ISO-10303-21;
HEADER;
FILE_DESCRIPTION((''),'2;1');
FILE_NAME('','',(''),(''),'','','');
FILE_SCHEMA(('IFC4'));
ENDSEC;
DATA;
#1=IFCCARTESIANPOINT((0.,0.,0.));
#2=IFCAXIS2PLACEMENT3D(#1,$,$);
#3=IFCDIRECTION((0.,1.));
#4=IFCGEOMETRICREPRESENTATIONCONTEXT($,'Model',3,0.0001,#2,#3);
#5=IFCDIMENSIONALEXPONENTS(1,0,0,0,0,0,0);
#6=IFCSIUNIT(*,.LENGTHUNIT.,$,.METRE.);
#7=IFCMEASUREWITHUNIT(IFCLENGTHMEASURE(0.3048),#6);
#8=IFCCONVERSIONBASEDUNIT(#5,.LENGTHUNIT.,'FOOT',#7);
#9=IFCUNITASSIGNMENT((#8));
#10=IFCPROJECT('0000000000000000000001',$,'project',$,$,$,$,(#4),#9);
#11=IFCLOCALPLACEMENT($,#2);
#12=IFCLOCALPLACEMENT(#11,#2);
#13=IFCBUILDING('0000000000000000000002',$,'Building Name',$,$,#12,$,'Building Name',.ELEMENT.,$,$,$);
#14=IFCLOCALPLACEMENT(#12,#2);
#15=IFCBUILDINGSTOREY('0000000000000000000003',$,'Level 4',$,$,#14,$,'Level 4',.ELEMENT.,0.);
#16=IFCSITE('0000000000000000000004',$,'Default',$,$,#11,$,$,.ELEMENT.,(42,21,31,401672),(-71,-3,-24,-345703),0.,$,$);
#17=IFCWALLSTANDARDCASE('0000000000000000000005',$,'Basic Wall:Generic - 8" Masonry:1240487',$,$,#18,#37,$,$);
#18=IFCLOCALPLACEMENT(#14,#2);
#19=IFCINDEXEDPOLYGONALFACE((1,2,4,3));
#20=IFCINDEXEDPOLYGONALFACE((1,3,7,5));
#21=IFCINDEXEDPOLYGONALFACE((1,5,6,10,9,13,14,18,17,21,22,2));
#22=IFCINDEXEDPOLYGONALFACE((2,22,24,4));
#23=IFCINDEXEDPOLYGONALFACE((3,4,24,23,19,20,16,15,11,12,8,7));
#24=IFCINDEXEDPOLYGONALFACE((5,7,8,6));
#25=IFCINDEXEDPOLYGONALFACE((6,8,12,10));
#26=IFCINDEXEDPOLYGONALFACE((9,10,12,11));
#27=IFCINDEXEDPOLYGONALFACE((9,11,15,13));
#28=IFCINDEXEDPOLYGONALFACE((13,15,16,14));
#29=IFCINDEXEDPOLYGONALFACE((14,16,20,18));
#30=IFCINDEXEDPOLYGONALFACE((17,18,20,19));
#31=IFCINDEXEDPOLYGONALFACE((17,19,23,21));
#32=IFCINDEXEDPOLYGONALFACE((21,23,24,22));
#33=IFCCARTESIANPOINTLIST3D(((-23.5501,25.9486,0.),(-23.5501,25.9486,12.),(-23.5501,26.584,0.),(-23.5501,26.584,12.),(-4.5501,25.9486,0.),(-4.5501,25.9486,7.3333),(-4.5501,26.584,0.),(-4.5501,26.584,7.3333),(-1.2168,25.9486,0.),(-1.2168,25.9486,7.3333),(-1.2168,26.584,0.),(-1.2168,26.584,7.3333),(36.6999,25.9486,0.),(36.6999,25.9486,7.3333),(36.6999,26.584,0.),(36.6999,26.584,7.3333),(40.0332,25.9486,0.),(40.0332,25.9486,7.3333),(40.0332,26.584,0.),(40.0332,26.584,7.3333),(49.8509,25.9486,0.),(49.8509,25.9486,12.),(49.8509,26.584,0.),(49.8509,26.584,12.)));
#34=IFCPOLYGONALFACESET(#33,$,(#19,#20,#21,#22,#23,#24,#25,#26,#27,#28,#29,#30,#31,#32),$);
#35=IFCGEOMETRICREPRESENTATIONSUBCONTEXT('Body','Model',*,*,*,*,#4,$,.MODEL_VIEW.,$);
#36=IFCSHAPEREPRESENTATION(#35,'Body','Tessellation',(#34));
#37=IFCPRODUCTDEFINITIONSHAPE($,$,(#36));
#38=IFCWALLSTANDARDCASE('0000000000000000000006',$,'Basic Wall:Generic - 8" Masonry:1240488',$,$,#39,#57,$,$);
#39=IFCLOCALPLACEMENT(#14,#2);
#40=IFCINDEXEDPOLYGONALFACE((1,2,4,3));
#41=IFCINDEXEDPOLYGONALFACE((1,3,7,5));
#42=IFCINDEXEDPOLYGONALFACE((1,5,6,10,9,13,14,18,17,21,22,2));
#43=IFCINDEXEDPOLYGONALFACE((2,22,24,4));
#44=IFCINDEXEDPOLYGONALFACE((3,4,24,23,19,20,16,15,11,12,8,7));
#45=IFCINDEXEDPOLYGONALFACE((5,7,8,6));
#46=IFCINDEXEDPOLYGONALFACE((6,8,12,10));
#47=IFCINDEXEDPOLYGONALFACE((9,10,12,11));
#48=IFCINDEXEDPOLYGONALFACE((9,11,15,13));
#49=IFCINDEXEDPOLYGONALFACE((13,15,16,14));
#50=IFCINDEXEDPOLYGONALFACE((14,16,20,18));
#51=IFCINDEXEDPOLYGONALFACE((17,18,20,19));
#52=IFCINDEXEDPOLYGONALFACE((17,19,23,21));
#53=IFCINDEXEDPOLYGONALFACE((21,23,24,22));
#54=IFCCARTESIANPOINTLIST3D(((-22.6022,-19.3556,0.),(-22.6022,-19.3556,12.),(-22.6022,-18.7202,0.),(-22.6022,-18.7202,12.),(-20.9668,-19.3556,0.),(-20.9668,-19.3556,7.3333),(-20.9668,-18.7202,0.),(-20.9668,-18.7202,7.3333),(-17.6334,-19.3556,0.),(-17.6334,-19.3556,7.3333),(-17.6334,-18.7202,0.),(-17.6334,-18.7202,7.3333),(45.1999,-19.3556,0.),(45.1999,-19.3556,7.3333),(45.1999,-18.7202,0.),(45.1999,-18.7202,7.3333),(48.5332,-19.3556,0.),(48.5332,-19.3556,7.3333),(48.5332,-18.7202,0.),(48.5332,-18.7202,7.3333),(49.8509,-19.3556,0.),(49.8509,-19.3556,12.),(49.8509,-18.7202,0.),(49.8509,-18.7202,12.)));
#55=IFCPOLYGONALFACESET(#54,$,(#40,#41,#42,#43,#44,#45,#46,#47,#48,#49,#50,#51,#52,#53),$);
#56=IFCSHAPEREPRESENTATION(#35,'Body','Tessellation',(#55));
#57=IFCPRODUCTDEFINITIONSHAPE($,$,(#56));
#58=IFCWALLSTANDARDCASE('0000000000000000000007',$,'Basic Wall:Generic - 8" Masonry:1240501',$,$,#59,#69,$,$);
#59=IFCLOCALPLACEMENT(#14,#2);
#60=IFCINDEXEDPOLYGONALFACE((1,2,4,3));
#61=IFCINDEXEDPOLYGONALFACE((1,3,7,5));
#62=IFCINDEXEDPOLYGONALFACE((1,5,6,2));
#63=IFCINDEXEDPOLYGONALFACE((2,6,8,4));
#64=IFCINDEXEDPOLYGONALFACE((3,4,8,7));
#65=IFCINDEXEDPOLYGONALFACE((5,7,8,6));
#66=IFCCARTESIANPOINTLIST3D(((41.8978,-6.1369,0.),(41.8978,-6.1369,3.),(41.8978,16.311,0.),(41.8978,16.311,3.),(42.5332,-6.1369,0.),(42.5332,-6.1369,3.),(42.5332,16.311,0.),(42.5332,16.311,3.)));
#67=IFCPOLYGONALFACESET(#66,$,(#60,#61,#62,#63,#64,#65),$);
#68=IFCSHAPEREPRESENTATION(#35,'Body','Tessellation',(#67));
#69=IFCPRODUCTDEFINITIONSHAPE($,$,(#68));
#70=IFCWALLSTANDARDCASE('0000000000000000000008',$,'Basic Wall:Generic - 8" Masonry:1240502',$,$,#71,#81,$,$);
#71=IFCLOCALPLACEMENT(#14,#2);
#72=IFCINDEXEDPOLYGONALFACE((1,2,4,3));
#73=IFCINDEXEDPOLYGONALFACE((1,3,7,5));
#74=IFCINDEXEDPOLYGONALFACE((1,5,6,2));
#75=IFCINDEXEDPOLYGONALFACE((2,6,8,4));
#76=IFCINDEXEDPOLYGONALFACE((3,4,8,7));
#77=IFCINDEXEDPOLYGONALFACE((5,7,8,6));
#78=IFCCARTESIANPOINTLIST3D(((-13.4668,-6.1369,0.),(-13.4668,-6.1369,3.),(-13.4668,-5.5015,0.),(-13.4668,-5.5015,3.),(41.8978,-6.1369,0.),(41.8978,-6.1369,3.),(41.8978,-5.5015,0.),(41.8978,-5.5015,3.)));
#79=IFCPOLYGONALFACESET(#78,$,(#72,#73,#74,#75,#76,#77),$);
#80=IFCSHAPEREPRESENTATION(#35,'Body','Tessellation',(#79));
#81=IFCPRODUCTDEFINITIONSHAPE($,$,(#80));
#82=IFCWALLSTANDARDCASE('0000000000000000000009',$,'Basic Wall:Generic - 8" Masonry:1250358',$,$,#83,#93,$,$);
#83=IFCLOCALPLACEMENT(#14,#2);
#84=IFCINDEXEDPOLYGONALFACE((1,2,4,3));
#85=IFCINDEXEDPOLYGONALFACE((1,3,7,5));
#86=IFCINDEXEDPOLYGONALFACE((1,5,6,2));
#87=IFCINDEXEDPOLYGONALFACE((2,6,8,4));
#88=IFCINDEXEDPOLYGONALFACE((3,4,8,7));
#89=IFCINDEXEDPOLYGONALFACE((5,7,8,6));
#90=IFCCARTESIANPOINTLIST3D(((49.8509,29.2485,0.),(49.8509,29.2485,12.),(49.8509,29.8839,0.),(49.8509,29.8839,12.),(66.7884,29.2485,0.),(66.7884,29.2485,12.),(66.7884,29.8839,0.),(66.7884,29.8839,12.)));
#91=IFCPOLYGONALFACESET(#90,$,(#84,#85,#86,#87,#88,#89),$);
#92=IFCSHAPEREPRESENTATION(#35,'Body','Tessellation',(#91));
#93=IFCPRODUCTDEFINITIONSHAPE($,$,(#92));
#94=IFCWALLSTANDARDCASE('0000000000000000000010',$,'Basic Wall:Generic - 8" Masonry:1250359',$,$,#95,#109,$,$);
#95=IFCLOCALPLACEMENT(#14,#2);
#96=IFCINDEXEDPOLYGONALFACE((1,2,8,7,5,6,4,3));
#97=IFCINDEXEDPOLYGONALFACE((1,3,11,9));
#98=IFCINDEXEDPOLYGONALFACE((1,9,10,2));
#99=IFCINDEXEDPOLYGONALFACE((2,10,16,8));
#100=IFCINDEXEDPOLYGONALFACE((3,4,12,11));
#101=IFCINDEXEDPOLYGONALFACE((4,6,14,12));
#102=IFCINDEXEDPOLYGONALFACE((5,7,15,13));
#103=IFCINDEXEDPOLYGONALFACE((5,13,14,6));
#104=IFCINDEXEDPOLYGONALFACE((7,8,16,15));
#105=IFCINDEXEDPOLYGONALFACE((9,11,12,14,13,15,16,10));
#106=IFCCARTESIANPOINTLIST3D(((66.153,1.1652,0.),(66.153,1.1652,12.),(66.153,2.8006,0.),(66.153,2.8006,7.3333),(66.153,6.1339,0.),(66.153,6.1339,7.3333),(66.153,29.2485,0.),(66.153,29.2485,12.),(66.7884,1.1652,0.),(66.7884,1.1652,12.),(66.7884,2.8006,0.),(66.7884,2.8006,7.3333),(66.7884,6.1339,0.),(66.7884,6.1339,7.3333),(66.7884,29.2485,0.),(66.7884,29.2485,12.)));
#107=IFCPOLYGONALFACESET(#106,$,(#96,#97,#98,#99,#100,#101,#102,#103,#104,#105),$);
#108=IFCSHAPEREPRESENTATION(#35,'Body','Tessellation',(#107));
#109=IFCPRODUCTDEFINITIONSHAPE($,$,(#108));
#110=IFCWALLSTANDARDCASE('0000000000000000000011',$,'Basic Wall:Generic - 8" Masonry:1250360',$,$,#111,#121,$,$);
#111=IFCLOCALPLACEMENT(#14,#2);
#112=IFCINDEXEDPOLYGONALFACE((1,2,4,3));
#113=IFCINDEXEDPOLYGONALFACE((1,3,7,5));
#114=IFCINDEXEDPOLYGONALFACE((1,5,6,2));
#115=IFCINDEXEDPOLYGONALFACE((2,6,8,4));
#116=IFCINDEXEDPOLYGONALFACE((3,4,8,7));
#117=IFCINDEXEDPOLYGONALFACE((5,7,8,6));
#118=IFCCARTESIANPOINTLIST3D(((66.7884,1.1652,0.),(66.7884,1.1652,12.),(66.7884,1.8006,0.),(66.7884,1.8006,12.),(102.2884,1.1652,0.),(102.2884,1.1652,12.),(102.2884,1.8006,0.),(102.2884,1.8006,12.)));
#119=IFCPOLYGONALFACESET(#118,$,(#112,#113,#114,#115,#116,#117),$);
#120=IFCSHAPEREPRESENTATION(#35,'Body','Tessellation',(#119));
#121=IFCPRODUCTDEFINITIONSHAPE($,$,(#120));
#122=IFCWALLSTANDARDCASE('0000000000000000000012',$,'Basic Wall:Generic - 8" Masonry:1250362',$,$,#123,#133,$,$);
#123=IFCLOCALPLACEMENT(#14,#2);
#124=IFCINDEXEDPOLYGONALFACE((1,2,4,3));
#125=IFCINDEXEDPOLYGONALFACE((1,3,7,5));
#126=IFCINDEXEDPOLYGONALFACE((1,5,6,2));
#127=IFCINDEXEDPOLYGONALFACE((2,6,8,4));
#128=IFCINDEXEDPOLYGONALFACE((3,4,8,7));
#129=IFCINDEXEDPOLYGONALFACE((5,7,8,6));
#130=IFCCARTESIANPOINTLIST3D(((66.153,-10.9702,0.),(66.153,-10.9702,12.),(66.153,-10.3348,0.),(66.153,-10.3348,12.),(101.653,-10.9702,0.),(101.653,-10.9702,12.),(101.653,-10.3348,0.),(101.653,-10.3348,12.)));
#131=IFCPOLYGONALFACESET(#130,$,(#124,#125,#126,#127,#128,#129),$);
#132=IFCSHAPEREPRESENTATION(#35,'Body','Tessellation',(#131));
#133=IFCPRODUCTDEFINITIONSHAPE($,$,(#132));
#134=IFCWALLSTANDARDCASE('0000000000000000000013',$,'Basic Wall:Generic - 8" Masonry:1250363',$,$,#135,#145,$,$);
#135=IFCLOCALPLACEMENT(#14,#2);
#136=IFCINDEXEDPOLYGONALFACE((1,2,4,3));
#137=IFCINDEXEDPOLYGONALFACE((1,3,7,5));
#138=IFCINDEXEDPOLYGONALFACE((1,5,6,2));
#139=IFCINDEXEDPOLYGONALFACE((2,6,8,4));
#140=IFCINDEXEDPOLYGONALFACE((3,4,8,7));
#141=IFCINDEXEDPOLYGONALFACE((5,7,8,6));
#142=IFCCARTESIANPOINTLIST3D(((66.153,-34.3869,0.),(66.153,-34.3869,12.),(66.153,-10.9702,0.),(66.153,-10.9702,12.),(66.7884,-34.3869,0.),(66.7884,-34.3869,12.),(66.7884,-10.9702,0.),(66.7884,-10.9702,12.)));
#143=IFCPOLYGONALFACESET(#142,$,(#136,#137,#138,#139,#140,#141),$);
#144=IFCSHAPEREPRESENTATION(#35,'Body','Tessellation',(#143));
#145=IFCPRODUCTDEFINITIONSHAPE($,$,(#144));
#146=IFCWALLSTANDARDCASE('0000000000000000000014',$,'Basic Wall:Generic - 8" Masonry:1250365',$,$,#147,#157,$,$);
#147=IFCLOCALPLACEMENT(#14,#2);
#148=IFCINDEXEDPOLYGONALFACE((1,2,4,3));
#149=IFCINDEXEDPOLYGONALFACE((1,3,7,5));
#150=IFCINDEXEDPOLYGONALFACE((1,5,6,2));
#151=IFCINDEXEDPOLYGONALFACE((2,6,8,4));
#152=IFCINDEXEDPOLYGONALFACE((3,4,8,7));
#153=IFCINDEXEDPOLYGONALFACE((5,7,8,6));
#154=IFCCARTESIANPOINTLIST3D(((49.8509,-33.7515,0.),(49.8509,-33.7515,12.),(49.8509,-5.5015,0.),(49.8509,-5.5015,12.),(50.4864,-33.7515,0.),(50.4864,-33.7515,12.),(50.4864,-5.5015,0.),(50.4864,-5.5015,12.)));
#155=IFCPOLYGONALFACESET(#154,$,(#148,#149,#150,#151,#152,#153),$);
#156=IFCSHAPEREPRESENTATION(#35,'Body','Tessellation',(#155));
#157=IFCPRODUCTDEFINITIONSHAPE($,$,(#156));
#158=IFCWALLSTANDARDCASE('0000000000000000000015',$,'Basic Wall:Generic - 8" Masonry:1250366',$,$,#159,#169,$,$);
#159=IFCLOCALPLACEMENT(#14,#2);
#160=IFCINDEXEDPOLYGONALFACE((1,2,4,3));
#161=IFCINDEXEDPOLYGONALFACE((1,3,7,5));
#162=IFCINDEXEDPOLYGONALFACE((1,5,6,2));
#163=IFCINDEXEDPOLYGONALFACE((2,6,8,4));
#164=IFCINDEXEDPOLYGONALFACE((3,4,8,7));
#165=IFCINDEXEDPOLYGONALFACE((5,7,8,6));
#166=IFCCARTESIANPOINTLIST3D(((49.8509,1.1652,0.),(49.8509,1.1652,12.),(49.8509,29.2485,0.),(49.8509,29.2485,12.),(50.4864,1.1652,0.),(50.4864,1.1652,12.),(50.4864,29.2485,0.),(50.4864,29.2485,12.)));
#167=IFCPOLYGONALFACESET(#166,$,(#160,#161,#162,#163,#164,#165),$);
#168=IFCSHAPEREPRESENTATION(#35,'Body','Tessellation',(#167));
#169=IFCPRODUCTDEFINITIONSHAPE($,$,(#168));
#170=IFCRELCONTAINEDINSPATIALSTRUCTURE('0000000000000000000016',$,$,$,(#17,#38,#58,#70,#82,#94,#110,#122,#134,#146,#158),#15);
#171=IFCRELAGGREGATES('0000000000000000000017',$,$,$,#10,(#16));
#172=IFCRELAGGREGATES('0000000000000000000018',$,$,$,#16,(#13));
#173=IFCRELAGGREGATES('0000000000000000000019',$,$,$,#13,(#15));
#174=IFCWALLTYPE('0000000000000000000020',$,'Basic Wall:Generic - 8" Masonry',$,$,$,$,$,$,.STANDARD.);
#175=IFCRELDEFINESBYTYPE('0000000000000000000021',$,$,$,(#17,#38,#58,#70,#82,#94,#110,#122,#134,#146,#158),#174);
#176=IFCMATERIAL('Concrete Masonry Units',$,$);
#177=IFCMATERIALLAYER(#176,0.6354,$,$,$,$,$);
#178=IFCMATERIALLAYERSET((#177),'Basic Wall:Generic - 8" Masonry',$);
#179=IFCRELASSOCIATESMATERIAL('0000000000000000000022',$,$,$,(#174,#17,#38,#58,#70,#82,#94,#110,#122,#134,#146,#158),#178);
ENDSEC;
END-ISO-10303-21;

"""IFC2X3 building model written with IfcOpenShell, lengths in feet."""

from ifc_helpers import new_model, entity, si_unit, converted_unit, direction, frame, frame_2d, origin, place, context, subcontext, project, spatial, rectangle, extrude, material, layer, layer_set, layer_usage, type_object, element, save


model = new_model("IFC2X3")

# Units and contexts
model_context = context("Model", 3, precision=0.0001, world=origin(), true_north=direction((0.0, 1.0)))
body_context = subcontext(model_context, "Body", "Model", "MODEL_VIEW")
ifc_project = project(units=[converted_unit("LENGTHUNIT", "FOOT", entity("IfcLengthMeasure", 0.3048), si_unit("LENGTHUNIT", "METRE"), dimensions=[1, 0, 0, 0, 0, 0, 0])], contexts=[model_context])

# Site, building, storey
site_placement = place(None, origin())
site = spatial("IfcSite", under=ifc_project, at=site_placement, Name="Default", CompositionType="ELEMENT", RefLatitude=(42, 21, 31, 401672), RefLongitude=(-71, -3, -24, -345703), RefElevation=0.0)
building_placement = place(site_placement, origin())
building = spatial("IfcBuilding", under=site, at=building_placement, Name="Building Name", LongName="Building Name", CompositionType="ELEMENT")
storey_placement = place(building_placement, origin())
storey = spatial("IfcBuildingStorey", under=building, at=storey_placement, Name="Level 4", LongName="Level 4", CompositionType="ELEMENT", Elevation=0.0)

# Walls, openings
ifc_material_1 = material(Name="Concrete Masonry Units")
ifc_layer_1 = layer(ifc_material_1, 0.6354)
ifc_layer_set_1 = layer_set([ifc_layer_1], Name="Basic Wall:Generic - 8\" Masonry")
ifc_layer_usage_1 = layer_usage(ifc_layer_set_1, "AXIS2", "NEGATIVE", 0.3177)
wall_type_1 = type_object("IfcWallType", Name="Basic Wall:Generic - 8\" Masonry", PredefinedType="STANDARD", material=ifc_layer_set_1)
wall_1_placement = place(storey_placement, frame((49.8509, 26.2663, 0.0), z_axis=(0.0, 0.0, 1.0), x_axis=(-1.0, 0.0, 0.0)))
wall_1 = element("IfcWallStandardCase", 1, at=wall_1_placement, inside=storey, type_object=wall_type_1, material=ifc_layer_usage_1, Name="Basic Wall:Generic - 8\" Masonry:1240487", context=body_context, shape_type="SweptSolid", body=[
    extrude(rectangle(XDim=73.401, YDim=0.6354, at=frame_2d((36.7005, 0.0), x_axis=(1.0, 0.0))), origin(), (0.0, 0.0, 1.0), 12.0),
])
opening_1_placement = place(wall_1_placement, frame((13.151, 0.3177, 0.0)))
element("IfcOpeningElement", 2, at=opening_1_placement, cuts=wall_1, ObjectType="Opening", context=body_context, shape_type="SweptSolid", body=[
    extrude(rectangle(XDim=7.3333, YDim=3.3333, at=frame_2d((3.6667, 1.6667), x_axis=(1.0, 0.0))), frame((0.0, 0.0, 0.0), z_axis=(0.0, -1.0, 0.0), x_axis=(0.0, 0.0, 1.0)), (0.0, 0.0, 1.0), 0.6354),
])
opening_2_placement = place(wall_1_placement, frame((54.401, 0.3177, 0.0)))
element("IfcOpeningElement", 3, at=opening_2_placement, cuts=wall_1, ObjectType="Opening", context=body_context, shape_type="SweptSolid", body=[
    extrude(rectangle(XDim=7.3333, YDim=3.3333, at=frame_2d((3.6667, 1.6667), x_axis=(1.0, 0.0))), frame((0.0, 0.0, 0.0), z_axis=(0.0, -1.0, 0.0), x_axis=(0.0, 0.0, 1.0)), (0.0, 0.0, 1.0), 0.6354),
])
ifc_layer_usage_2 = layer_usage(ifc_layer_set_1, "AXIS2", "NEGATIVE", 0.3177)
wall_2_placement = place(storey_placement, frame((49.8509, -19.0379, 0.0), z_axis=(0.0, 0.0, 1.0), x_axis=(-1.0, 0.0, 0.0)))
wall_2 = element("IfcWallStandardCase", 4, at=wall_2_placement, inside=storey, type_object=wall_type_1, material=ifc_layer_usage_2, Name="Basic Wall:Generic - 8\" Masonry:1240488", context=body_context, shape_type="SweptSolid", body=[
    extrude(rectangle(XDim=72.4531, YDim=0.6354, at=frame_2d((36.2266, 0.0), x_axis=(1.0, 0.0))), origin(), (0.0, 0.0, 1.0), 12.0),
])
opening_3_placement = place(wall_2_placement, frame((1.3177, -0.3177, 0.0)))
element("IfcOpeningElement", 5, at=opening_3_placement, cuts=wall_2, ObjectType="Opening", context=body_context, shape_type="SweptSolid", body=[
    extrude(rectangle(XDim=7.3333, YDim=3.3333, at=frame_2d((3.6667, 1.6667), x_axis=(1.0, 0.0))), frame((0.0, 0.0, 0.0), z_axis=(0.0, 1.0, 0.0), x_axis=(0.0, 0.0, 1.0)), (0.0, 0.0, 1.0), 0.6354),
])
opening_4_placement = place(wall_2_placement, frame((67.4844, -0.3177, 0.0)))
element("IfcOpeningElement", 6, at=opening_4_placement, cuts=wall_2, ObjectType="Opening", context=body_context, shape_type="SweptSolid", body=[
    extrude(rectangle(XDim=7.3333, YDim=3.3333, at=frame_2d((3.6667, 1.6667), x_axis=(1.0, 0.0))), frame((0.0, 0.0, 0.0), z_axis=(0.0, 1.0, 0.0), x_axis=(0.0, 0.0, 1.0)), (0.0, 0.0, 1.0), 0.6354),
])

# Walls
ifc_layer_usage_3 = layer_usage(ifc_layer_set_1, "AXIS2", "NEGATIVE", 0.3177)
wall_3_placement = place(storey_placement, frame((42.2155, 16.311, 0.0), z_axis=(0.0, 0.0, 1.0), x_axis=(0.0, -1.0, 0.0)))
element("IfcWallStandardCase", 7, at=wall_3_placement, inside=storey, type_object=wall_type_1, material=ifc_layer_usage_3, Name="Basic Wall:Generic - 8\" Masonry:1240501", context=body_context, shape_type="SweptSolid", body=[
    extrude(rectangle(XDim=22.4479, YDim=0.6354, at=frame_2d((11.224, 0.0), x_axis=(-1.0, 0.0))), origin(), (0.0, 0.0, 1.0), 3.0),
])
ifc_layer_usage_4 = layer_usage(ifc_layer_set_1, "AXIS2", "NEGATIVE", 0.3177)
wall_4_placement = place(storey_placement, frame((41.8978, -5.8192, 0.0), z_axis=(0.0, 0.0, 1.0), x_axis=(-1.0, 0.0, 0.0)))
element("IfcWallStandardCase", 8, at=wall_4_placement, inside=storey, type_object=wall_type_1, material=ifc_layer_usage_4, Name="Basic Wall:Generic - 8\" Masonry:1240502", context=body_context, shape_type="SweptSolid", body=[
    extrude(rectangle(XDim=55.3646, YDim=0.6354, at=frame_2d((27.6823, 0.0), x_axis=(-1.0, 0.0))), origin(), (0.0, 0.0, 1.0), 3.0),
])
ifc_layer_usage_5 = layer_usage(ifc_layer_set_1, "AXIS2", "NEGATIVE", 0.3177)
wall_5_placement = place(storey_placement, frame((49.8509, 29.5662, 0.0)))
element("IfcWallStandardCase", 9, at=wall_5_placement, inside=storey, type_object=wall_type_1, material=ifc_layer_usage_5, Name="Basic Wall:Generic - 8\" Masonry:1250358", context=body_context, shape_type="SweptSolid", body=[
    extrude(rectangle(XDim=16.9375, YDim=0.6354, at=frame_2d((8.4688, 0.0), x_axis=(-1.0, 0.0))), origin(), (0.0, 0.0, 1.0), 12.0),
])

# Wall, opening
ifc_layer_usage_6 = layer_usage(ifc_layer_set_1, "AXIS2", "NEGATIVE", 0.3177)
wall_6_placement = place(storey_placement, frame((66.4707, 29.2485, 0.0), z_axis=(0.0, 0.0, 1.0), x_axis=(0.0, -1.0, 0.0)))
wall_6 = element("IfcWallStandardCase", 10, at=wall_6_placement, inside=storey, type_object=wall_type_1, material=ifc_layer_usage_6, Name="Basic Wall:Generic - 8\" Masonry:1250359", context=body_context, shape_type="SweptSolid", body=[
    extrude(rectangle(XDim=28.0833, YDim=0.6354, at=frame_2d((14.0417, 0.0), x_axis=(1.0, 0.0))), origin(), (0.0, 0.0, 1.0), 12.0),
])
opening_5_placement = place(wall_6_placement, frame((23.1146, -0.3177, 0.0)))
element("IfcOpeningElement", 11, at=opening_5_placement, cuts=wall_6, ObjectType="Opening", context=body_context, shape_type="SweptSolid", body=[
    extrude(rectangle(XDim=7.3333, YDim=3.3333, at=frame_2d((3.6667, 1.6667), x_axis=(1.0, 0.0))), frame((0.0, 0.0, 0.0), z_axis=(0.0, 1.0, 0.0), x_axis=(0.0, 0.0, 1.0)), (0.0, 0.0, 1.0), 0.6354),
])

# Wall
ifc_layer_usage_7 = layer_usage(ifc_layer_set_1, "AXIS2", "NEGATIVE", 0.3177)
wall_7_placement = place(storey_placement, frame((66.7884, 1.4829, 0.0)))
element("IfcWallStandardCase", 12, at=wall_7_placement, inside=storey, type_object=wall_type_1, material=ifc_layer_usage_7, Name="Basic Wall:Generic - 8\" Masonry:1250360", context=body_context, shape_type="SweptSolid", body=[
    extrude(rectangle(XDim=35.5, YDim=0.6354, at=frame_2d((17.75, 0.0), x_axis=(-1.0, 0.0))), origin(), (0.0, 0.0, 1.0), 12.0),
])

# Walls
ifc_layer_usage_8 = layer_usage(ifc_layer_set_1, "AXIS2", "NEGATIVE", 0.3177)
wall_8_placement = place(storey_placement, frame((101.653, -10.6525, 0.0), z_axis=(0.0, 0.0, 1.0), x_axis=(-1.0, 0.0, 0.0)))
element("IfcWallStandardCase", 13, at=wall_8_placement, inside=storey, type_object=wall_type_1, material=ifc_layer_usage_8, Name="Basic Wall:Generic - 8\" Masonry:1250362", context=body_context, shape_type="SweptSolid", body=[
    extrude(rectangle(XDim=35.5, YDim=0.6354, at=frame_2d((17.75, 0.0), x_axis=(-1.0, 0.0))), origin(), (0.0, 0.0, 1.0), 12.0),
])
ifc_layer_usage_9 = layer_usage(ifc_layer_set_1, "AXIS2", "NEGATIVE", 0.3177)
wall_9_placement = place(storey_placement, frame((66.4707, -10.9702, 0.0), z_axis=(0.0, 0.0, 1.0), x_axis=(0.0, -1.0, 0.0)))
element("IfcWallStandardCase", 14, at=wall_9_placement, inside=storey, type_object=wall_type_1, material=ifc_layer_usage_9, Name="Basic Wall:Generic - 8\" Masonry:1250363", context=body_context, shape_type="SweptSolid", body=[
    extrude(rectangle(XDim=23.4167, YDim=0.6354, at=frame_2d((11.7083, 0.0), x_axis=(-1.0, 0.0))), origin(), (0.0, 0.0, 1.0), 12.0),
])

# Walls
ifc_layer_usage_10 = layer_usage(ifc_layer_set_1, "AXIS2", "NEGATIVE", 0.3177)
wall_10_placement = place(storey_placement, frame((50.1686, -33.7515, 0.0), z_axis=(0.0, 0.0, 1.0), x_axis=(0.0, 1.0, 0.0)))
element("IfcWallStandardCase", 15, at=wall_10_placement, inside=storey, type_object=wall_type_1, material=ifc_layer_usage_10, Name="Basic Wall:Generic - 8\" Masonry:1250365", context=body_context, shape_type="SweptSolid", body=[
    extrude(rectangle(XDim=28.25, YDim=0.6354, at=frame_2d((14.125, 0.0), x_axis=(-1.0, 0.0))), origin(), (0.0, 0.0, 1.0), 12.0),
])
ifc_layer_usage_11 = layer_usage(ifc_layer_set_1, "AXIS2", "NEGATIVE", 0.3177)
wall_11_placement = place(storey_placement, frame((50.1686, 29.2485, 0.0), z_axis=(0.0, 0.0, 1.0), x_axis=(0.0, -1.0, 0.0)))
element("IfcWallStandardCase", 16, at=wall_11_placement, inside=storey, type_object=wall_type_1, material=ifc_layer_usage_11, Name="Basic Wall:Generic - 8\" Masonry:1250366", context=body_context, shape_type="SweptSolid", body=[
    extrude(rectangle(XDim=28.0833, YDim=0.6354, at=frame_2d((14.0417, 0.0), x_axis=(-1.0, 0.0))), origin(), (0.0, 0.0, 1.0), 12.0),
])

save(model, "model.ifc")
